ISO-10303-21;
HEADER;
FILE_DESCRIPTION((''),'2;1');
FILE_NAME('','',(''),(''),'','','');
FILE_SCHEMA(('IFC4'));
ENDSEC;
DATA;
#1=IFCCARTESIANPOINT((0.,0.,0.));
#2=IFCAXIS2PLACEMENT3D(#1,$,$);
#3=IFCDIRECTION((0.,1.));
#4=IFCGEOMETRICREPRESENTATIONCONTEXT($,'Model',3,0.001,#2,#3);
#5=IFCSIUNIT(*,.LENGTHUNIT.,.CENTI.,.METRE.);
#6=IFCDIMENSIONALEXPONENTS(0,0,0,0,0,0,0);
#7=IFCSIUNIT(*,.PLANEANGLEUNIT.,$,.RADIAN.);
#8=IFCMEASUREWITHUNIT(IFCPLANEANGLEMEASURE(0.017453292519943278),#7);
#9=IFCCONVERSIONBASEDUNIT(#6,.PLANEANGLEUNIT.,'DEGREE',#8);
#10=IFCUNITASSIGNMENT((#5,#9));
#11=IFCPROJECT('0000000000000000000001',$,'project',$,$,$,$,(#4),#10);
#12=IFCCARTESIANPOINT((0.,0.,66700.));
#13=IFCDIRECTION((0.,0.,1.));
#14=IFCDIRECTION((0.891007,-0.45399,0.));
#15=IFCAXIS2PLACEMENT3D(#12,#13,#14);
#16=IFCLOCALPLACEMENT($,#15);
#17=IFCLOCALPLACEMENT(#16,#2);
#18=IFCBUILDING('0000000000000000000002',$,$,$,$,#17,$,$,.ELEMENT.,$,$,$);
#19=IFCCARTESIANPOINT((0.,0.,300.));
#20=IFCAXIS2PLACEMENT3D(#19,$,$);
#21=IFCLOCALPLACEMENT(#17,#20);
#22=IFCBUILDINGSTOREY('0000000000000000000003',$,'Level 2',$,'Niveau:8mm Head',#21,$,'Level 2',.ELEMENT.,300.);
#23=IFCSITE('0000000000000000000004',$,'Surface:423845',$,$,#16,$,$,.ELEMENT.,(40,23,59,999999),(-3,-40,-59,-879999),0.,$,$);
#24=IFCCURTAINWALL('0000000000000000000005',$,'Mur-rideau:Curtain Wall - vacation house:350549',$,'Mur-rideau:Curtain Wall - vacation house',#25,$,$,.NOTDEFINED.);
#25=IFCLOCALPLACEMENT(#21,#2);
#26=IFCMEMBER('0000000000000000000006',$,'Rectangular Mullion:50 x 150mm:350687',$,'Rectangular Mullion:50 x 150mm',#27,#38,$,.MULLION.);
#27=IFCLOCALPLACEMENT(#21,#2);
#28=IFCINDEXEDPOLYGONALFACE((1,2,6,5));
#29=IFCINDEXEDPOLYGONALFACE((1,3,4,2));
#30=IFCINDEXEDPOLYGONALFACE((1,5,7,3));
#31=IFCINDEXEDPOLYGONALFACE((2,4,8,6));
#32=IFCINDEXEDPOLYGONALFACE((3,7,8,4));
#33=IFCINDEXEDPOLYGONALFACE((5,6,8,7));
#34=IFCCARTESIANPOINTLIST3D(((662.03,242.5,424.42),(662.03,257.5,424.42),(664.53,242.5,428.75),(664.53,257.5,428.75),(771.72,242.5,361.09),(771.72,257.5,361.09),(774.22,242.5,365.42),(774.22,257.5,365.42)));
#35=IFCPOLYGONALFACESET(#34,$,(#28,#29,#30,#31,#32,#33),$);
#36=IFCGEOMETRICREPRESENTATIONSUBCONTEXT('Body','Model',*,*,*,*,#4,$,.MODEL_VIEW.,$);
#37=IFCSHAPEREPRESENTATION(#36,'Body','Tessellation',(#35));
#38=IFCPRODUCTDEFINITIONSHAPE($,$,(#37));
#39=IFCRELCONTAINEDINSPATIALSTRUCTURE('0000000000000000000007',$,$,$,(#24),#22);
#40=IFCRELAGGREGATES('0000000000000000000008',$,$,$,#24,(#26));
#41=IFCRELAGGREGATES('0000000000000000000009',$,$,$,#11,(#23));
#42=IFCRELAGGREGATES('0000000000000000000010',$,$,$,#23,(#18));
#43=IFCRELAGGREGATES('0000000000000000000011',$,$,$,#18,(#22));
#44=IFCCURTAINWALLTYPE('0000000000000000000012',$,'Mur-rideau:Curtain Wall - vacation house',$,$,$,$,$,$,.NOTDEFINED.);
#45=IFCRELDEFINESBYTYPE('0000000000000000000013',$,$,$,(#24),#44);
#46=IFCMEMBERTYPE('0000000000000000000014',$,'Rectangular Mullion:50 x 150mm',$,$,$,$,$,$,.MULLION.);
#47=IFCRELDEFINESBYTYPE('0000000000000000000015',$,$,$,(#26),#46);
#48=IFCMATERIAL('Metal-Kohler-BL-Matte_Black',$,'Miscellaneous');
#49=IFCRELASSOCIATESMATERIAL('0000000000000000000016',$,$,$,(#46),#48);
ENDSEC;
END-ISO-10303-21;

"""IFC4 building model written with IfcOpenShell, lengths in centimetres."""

from ifc_helpers import new_model, entity, si_unit, converted_unit, direction, frame, origin, origin_2d_with_axis, place, context, subcontext, project, spatial, rectangle, extrude, source, transform, mapped, material, material_profile, profile_set, type_object, type_shapes, element, aggregate, save


model = new_model("IFC4")

# Units and contexts
model_context = context("Model", 3, precision=0.001, world=origin(), true_north=direction((0.0, 1.0)))
body_context = subcontext(model_context, "Body", "Model", "MODEL_VIEW")
ifc_project = project(units=[si_unit("LENGTHUNIT", "METRE", prefix="CENTI"), converted_unit("PLANEANGLEUNIT", "DEGREE", entity("IfcPlaneAngleMeasure", 0.017453292519943278), si_unit("PLANEANGLEUNIT", "RADIAN"), dimensions=[0, 0, 0, 0, 0, 0, 0])], contexts=[model_context])

# Site, building, storey
site_placement = place(None, frame((0.0, 0.0, 66700.0), z_axis=(0.0, 0.0, 1.0), x_axis=(0.891007, -0.45399, 0.0)))
site = spatial("IfcSite", under=ifc_project, at=site_placement, Name="Surface:423845", CompositionType="ELEMENT", RefLatitude=(40, 23, 59, 999999), RefLongitude=(-3, -40, -59, -879999), RefElevation=0.0)
building_placement = place(site_placement, origin())
building = spatial("IfcBuilding", under=site, at=building_placement, CompositionType="ELEMENT")
storey_placement = place(building_placement, frame((0.0, 0.0, 300.0)))
storey = spatial("IfcBuildingStorey", under=building, at=storey_placement, Name="Level 2", ObjectType="Niveau:8mm Head", LongName="Level 2", CompositionType="ELEMENT", Elevation=300.0)

# Curtain wall, member
curtain_wall_type = type_object("IfcCurtainWallType", Name="Mur-rideau:Curtain Wall - vacation house", PredefinedType="NOTDEFINED")
curtain_wall_placement = place(storey_placement, frame((0.0, 0.0, -300.0)))
curtain_wall = element("IfcCurtainWall", 1, at=curtain_wall_placement, inside=storey, type_object=curtain_wall_type, Name="Mur-rideau:Curtain Wall - vacation house:350549", ObjectType="Mur-rideau:Curtain Wall - vacation house", PredefinedType="NOTDEFINED")
ifc_material_1 = material(Name="Metal-Kohler-BL-Matte_Black", Category="Miscellaneous")
ifc_material_profile = material_profile(ifc_material_1, rectangle(XDim=5.0, YDim=15.0, at=origin_2d_with_axis()), Name="50 x 150mm")
ifc_profile_set = profile_set([ifc_material_profile], Name="50 x 150mm")
member_type_1 = type_object("IfcMemberType", Name="Rectangular Mullion:50 x 150mm", PredefinedType="MULLION", material=ifc_profile_set)
shared_shape_1 = source(origin(), body_context, "Body", "SweptSolid", [
    extrude(rectangle(XDim=5.0, YDim=15.0, at=origin_2d_with_axis()), frame((-2.5, 0.0, -126.66), z_axis=(0.0, 0.0, 1.0), x_axis=(-1.0, 0.0, 0.0)), (0.0, 0.0, 1.0), 126.66),
])
type_shapes(member_type_1, [shared_shape_1])
member_1_placement = place(curtain_wall_placement, frame((664.53, 250.0, 728.75), z_axis=(-0.866025, 0.0, 0.5), x_axis=(0.5, 0.0, 0.866025)))
member_1 = element("IfcMember", 2, at=member_1_placement, type_object=member_type_1, Name="Rectangular Mullion:50 x 150mm:350687", ObjectType="Rectangular Mullion:50 x 150mm", PredefinedType="MULLION", context=body_context, shape_type="MappedRepresentation", body=[
    mapped(shared_shape_1, transform((0.0, 0.0, 0.0), scale=1.0)),
])
aggregate(curtain_wall, [member_1])

save(model, "model.ifc")
